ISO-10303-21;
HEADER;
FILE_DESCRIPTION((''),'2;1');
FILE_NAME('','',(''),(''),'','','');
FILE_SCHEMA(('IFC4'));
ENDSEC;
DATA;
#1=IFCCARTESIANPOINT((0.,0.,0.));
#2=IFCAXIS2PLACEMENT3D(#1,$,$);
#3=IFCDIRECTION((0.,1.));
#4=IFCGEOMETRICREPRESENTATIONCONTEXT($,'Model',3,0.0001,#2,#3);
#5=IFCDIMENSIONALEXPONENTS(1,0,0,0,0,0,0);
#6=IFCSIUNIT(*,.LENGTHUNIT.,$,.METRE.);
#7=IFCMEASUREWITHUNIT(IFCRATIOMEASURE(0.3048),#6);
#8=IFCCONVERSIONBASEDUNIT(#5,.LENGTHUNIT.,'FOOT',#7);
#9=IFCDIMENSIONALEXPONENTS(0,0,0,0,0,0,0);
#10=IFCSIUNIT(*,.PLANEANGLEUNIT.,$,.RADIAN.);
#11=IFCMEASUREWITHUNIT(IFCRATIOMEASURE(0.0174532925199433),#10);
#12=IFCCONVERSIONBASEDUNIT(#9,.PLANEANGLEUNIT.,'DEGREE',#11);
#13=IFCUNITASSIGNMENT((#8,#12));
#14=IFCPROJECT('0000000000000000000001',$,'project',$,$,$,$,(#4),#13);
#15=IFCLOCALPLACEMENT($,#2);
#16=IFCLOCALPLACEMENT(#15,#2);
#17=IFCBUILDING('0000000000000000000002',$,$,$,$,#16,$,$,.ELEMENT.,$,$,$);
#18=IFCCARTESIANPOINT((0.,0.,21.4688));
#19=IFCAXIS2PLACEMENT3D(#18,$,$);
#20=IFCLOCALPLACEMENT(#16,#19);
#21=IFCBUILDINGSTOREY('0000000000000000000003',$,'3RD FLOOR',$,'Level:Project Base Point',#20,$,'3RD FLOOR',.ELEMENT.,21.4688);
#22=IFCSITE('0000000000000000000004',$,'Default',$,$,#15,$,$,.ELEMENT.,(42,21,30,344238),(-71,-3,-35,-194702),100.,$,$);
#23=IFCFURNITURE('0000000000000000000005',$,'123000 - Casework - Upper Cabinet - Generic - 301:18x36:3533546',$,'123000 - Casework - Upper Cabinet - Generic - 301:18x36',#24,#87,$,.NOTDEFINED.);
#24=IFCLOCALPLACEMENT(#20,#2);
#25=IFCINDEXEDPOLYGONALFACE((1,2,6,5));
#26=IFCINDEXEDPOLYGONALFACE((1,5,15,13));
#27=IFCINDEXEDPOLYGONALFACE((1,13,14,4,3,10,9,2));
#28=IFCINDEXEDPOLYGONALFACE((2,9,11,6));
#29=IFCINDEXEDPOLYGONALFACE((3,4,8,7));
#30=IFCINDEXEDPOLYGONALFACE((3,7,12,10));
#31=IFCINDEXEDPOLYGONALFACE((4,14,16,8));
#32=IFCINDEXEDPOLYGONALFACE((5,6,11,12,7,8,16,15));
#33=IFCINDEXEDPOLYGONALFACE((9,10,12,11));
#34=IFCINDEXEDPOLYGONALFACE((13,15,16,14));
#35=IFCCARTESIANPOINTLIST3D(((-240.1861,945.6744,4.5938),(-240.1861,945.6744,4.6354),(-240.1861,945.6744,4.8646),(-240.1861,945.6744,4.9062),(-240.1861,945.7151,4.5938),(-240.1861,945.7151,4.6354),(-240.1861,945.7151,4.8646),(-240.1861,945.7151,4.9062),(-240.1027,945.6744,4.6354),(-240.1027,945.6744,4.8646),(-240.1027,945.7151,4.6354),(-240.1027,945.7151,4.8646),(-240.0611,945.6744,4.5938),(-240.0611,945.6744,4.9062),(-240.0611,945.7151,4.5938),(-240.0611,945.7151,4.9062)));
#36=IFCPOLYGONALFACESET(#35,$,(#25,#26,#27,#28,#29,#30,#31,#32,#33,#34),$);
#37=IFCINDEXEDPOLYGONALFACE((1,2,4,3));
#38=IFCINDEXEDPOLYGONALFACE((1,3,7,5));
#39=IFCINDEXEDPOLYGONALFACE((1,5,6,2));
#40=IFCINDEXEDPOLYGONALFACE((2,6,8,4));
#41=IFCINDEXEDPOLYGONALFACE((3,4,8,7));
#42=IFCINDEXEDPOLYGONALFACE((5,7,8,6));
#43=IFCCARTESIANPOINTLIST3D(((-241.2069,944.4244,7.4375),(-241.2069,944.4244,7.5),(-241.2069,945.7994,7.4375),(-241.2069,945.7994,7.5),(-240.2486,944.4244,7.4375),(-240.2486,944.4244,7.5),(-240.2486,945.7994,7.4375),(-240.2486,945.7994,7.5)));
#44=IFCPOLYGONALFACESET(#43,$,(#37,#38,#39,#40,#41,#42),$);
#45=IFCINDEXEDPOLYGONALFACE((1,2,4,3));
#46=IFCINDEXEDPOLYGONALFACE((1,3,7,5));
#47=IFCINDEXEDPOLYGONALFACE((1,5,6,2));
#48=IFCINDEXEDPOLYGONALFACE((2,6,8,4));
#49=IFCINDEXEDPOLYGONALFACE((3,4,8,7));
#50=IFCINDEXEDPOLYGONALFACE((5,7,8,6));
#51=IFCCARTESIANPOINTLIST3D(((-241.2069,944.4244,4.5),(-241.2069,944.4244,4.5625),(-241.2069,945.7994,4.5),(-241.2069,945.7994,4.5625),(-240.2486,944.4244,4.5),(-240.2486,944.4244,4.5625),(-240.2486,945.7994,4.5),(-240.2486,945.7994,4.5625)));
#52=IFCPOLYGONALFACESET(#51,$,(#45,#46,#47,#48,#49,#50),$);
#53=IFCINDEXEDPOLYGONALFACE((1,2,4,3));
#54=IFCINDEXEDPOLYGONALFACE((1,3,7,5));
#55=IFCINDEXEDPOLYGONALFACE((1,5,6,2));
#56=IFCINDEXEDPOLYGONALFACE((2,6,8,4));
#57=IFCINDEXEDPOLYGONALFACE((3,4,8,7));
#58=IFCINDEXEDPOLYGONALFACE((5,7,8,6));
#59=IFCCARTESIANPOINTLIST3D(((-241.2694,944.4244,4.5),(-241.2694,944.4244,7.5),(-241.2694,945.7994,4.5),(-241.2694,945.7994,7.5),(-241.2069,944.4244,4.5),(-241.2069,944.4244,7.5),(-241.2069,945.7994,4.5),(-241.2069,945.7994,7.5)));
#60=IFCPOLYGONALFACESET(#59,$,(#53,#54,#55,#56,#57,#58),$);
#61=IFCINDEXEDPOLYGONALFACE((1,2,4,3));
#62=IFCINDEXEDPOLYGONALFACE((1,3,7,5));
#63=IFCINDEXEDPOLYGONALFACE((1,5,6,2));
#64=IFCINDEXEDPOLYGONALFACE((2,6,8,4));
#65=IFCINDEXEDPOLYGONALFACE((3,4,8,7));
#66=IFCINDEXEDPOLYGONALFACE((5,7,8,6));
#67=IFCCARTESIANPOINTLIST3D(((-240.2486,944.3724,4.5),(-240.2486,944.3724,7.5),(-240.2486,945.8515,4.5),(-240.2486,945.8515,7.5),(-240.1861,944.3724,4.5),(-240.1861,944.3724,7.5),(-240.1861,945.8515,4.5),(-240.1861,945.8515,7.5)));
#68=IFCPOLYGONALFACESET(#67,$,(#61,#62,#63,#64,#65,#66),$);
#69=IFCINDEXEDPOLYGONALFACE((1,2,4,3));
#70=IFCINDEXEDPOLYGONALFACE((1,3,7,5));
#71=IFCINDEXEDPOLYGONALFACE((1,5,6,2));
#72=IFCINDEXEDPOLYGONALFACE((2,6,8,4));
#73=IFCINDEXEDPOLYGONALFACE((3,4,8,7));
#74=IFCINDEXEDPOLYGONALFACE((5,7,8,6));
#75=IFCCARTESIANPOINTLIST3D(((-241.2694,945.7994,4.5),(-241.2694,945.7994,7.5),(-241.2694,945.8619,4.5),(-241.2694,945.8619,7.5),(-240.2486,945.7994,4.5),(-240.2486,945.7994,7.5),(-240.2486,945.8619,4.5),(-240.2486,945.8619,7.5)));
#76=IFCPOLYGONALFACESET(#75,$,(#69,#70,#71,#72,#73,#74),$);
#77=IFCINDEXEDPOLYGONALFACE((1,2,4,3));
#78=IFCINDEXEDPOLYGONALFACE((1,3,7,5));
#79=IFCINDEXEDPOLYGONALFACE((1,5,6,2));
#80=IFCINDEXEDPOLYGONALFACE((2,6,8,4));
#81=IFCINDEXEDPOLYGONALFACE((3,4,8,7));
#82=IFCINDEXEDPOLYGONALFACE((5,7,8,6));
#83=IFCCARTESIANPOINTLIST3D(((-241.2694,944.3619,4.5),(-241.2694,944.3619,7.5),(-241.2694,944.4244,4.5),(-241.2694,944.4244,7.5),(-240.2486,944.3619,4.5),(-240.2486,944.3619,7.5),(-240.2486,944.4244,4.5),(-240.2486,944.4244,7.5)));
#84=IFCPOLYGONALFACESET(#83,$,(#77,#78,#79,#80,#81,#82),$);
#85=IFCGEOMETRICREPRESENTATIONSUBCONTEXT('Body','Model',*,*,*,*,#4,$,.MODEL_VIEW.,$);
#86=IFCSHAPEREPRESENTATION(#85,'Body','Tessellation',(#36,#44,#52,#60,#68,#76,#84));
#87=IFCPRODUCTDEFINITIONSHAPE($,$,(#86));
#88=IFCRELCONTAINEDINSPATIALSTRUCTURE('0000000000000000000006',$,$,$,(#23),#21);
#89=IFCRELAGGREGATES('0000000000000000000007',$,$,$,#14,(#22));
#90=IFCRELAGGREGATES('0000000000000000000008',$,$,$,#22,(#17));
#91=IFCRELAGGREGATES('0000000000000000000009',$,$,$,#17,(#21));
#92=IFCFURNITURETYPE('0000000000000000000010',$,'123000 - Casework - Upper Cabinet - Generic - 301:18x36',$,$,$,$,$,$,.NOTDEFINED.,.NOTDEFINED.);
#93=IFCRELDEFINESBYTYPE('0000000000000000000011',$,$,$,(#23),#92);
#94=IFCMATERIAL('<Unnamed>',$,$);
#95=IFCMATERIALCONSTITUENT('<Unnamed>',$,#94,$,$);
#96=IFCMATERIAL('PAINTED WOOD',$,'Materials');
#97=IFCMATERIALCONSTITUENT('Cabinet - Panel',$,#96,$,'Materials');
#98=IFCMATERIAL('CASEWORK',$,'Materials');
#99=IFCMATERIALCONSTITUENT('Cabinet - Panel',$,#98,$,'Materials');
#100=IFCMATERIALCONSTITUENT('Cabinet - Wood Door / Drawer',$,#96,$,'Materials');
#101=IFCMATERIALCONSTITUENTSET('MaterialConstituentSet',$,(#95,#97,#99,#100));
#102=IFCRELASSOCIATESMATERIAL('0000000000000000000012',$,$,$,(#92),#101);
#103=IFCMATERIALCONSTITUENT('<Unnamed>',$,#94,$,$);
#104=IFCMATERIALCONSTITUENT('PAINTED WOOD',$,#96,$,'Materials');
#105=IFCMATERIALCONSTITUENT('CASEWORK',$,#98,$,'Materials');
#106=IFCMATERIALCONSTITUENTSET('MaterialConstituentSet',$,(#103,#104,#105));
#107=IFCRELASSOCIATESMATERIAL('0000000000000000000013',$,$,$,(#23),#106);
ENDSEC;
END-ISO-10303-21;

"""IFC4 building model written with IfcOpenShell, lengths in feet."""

from ifc_helpers import new_model, entity, si_unit, converted_unit, direction, frame, frame_2d, origin, origin_2d_with_axis, place, context, subcontext, project, spatial, polyline, rectangle, outline, extrude, source, transform, mapped, material, constituent, constituent_set, type_object, type_shapes, element, save


model = new_model("IFC4")

# Units and contexts
model_context = context("Model", 3, precision=0.0001, world=origin(), true_north=direction((0.0, 1.0)))
body_context = subcontext(model_context, "Body", "Model", "MODEL_VIEW")
ifc_project = project(units=[converted_unit("LENGTHUNIT", "FOOT", entity("IfcRatioMeasure", 0.3048), si_unit("LENGTHUNIT", "METRE"), dimensions=[1, 0, 0, 0, 0, 0, 0]), converted_unit("PLANEANGLEUNIT", "DEGREE", entity("IfcRatioMeasure", 0.0174532925199433), si_unit("PLANEANGLEUNIT", "RADIAN"), dimensions=[0, 0, 0, 0, 0, 0, 0])], contexts=[model_context])

# Site, building, storey
site_placement = place(None, origin())
site = spatial("IfcSite", under=ifc_project, at=site_placement, Name="Default", CompositionType="ELEMENT", RefLatitude=(42, 21, 30, 344238), RefLongitude=(-71, -3, -35, -194702), RefElevation=100.0)
building_placement = place(site_placement, origin())
building = spatial("IfcBuilding", under=site, at=building_placement, CompositionType="ELEMENT")
storey_placement = place(building_placement, frame((0.0, 0.0, 21.4688)))
storey = spatial("IfcBuildingStorey", under=building, at=storey_placement, Name="3RD FLOOR", ObjectType="Level:Project Base Point", LongName="3RD FLOOR", CompositionType="ELEMENT", Elevation=21.4688)

# Furniture
ifc_material_1 = material(Name="PAINTED WOOD", Category="Materials")
ifc_material_2 = material(Name="CASEWORK", Category="Materials")
ifc_material_3 = material(Name="<Unnamed>")
ifc_constituent_1 = constituent(ifc_material_3, Name="<Unnamed>")
ifc_constituent_2 = constituent(ifc_material_1, Name="PAINTED WOOD", Category="Materials")
ifc_constituent_3 = constituent(ifc_material_2, Name="CASEWORK", Category="Materials")
ifc_constituent_set_1 = constituent_set(constituents=[ifc_constituent_1, ifc_constituent_2, ifc_constituent_3], Name="MaterialConstituentSet")
ifc_constituent_4 = constituent(ifc_material_3, Name="<Unnamed>")
ifc_constituent_5 = constituent(ifc_material_1, Name="Cabinet - Panel", Category="Materials")
ifc_constituent_6 = constituent(ifc_material_2, Name="Cabinet - Panel", Category="Materials")
ifc_constituent_7 = constituent(ifc_material_1, Name="Cabinet - Wood Door / Drawer", Category="Materials")
ifc_constituent_set_2 = constituent_set(constituents=[ifc_constituent_4, ifc_constituent_5, ifc_constituent_6, ifc_constituent_7], Name="MaterialConstituentSet")
furniture_type_1 = type_object("IfcFurnitureType", Name="123000 - Casework - Upper Cabinet - Generic - 301:18x36", AssemblyPlace="NOTDEFINED", PredefinedType="NOTDEFINED", material=ifc_constituent_set_2)
shared_shape_1 = source(origin(), body_context, "Body", "SweptSolid", [
    extrude(outline(polyline([(-0.0521, -0.1146), (-0.0521, -0.1562), (0.0729, -0.1562), (0.0729, 0.1562), (-0.0521, 0.1562), (-0.0521, 0.1146), (0.0313, 0.1146), (0.0313, -0.1146), (-0.0521, -0.1146)])), frame((0.1468, 1.1354, 0.25), z_axis=(-1.0, 0.0, 0.0), x_axis=(0.0, 1.0, 0.0)), (0.0, 0.0, -1.0), 0.0407),
    extrude(rectangle(XDim=0.9583, YDim=1.375, at=frame_2d((0.0, 0.0), x_axis=(1.0, 0.0))), frame((0.75, 0.5417, 2.9375), z_axis=(0.0, 0.0, 1.0), x_axis=(0.0, 1.0, 0.0)), (0.0, 0.0, 1.0), 0.0625),
    extrude(rectangle(XDim=0.9583, YDim=1.375, at=frame_2d((0.0, 0.0), x_axis=(1.0, 0.0))), frame((0.75, 0.5417, 0.0), z_axis=(0.0, 0.0, 1.0), x_axis=(0.0, 1.0, 0.0)), (0.0, 0.0, 1.0), 0.0625),
    extrude(rectangle(XDim=1.375, YDim=0.0625, at=origin_2d_with_axis()), frame((0.75, 0.0313, 0.0), z_axis=(0.0, 0.0, 1.0), x_axis=(-1.0, 0.0, 0.0)), (0.0, 0.0, 1.0), 3.0),
    extrude(rectangle(XDim=1.4792, YDim=0.0625, at=origin_2d_with_axis()), frame((0.75, 1.0521, 0.0)), (0.0, 0.0, 1.0), 3.0),
    extrude(rectangle(XDim=1.0208, YDim=0.0625, at=origin_2d_with_axis()), frame((0.0312, 0.5104, 0.0), z_axis=(0.0, 0.0, 1.0), x_axis=(0.0, 1.0, 0.0)), (0.0, 0.0, 1.0), 3.0),
    extrude(rectangle(XDim=1.0208, YDim=0.0625, at=origin_2d_with_axis()), frame((1.4688, 0.5104, 0.0), z_axis=(0.0, 0.0, 1.0), x_axis=(0.0, 1.0, 0.0)), (0.0, 0.0, 1.0), 3.0),
])
type_shapes(furniture_type_1, [shared_shape_1])
furniture_1_placement = place(storey_placement, frame((-241.2694, 945.8619, 4.5), z_axis=(0.0, 0.0, 1.0), x_axis=(0.0, -1.0, 0.0)))
element("IfcFurniture", 1, at=furniture_1_placement, inside=storey, type_object=furniture_type_1, material=ifc_constituent_set_1, Name="123000 - Casework - Upper Cabinet - Generic - 301:18x36:3533546", ObjectType="123000 - Casework - Upper Cabinet - Generic - 301:18x36", PredefinedType="NOTDEFINED", context=body_context, shape_type="MappedRepresentation", body=[
    mapped(shared_shape_1, transform((0.0, 0.0, 0.0), scale=1.0)),
])

save(model, "model.ifc")
